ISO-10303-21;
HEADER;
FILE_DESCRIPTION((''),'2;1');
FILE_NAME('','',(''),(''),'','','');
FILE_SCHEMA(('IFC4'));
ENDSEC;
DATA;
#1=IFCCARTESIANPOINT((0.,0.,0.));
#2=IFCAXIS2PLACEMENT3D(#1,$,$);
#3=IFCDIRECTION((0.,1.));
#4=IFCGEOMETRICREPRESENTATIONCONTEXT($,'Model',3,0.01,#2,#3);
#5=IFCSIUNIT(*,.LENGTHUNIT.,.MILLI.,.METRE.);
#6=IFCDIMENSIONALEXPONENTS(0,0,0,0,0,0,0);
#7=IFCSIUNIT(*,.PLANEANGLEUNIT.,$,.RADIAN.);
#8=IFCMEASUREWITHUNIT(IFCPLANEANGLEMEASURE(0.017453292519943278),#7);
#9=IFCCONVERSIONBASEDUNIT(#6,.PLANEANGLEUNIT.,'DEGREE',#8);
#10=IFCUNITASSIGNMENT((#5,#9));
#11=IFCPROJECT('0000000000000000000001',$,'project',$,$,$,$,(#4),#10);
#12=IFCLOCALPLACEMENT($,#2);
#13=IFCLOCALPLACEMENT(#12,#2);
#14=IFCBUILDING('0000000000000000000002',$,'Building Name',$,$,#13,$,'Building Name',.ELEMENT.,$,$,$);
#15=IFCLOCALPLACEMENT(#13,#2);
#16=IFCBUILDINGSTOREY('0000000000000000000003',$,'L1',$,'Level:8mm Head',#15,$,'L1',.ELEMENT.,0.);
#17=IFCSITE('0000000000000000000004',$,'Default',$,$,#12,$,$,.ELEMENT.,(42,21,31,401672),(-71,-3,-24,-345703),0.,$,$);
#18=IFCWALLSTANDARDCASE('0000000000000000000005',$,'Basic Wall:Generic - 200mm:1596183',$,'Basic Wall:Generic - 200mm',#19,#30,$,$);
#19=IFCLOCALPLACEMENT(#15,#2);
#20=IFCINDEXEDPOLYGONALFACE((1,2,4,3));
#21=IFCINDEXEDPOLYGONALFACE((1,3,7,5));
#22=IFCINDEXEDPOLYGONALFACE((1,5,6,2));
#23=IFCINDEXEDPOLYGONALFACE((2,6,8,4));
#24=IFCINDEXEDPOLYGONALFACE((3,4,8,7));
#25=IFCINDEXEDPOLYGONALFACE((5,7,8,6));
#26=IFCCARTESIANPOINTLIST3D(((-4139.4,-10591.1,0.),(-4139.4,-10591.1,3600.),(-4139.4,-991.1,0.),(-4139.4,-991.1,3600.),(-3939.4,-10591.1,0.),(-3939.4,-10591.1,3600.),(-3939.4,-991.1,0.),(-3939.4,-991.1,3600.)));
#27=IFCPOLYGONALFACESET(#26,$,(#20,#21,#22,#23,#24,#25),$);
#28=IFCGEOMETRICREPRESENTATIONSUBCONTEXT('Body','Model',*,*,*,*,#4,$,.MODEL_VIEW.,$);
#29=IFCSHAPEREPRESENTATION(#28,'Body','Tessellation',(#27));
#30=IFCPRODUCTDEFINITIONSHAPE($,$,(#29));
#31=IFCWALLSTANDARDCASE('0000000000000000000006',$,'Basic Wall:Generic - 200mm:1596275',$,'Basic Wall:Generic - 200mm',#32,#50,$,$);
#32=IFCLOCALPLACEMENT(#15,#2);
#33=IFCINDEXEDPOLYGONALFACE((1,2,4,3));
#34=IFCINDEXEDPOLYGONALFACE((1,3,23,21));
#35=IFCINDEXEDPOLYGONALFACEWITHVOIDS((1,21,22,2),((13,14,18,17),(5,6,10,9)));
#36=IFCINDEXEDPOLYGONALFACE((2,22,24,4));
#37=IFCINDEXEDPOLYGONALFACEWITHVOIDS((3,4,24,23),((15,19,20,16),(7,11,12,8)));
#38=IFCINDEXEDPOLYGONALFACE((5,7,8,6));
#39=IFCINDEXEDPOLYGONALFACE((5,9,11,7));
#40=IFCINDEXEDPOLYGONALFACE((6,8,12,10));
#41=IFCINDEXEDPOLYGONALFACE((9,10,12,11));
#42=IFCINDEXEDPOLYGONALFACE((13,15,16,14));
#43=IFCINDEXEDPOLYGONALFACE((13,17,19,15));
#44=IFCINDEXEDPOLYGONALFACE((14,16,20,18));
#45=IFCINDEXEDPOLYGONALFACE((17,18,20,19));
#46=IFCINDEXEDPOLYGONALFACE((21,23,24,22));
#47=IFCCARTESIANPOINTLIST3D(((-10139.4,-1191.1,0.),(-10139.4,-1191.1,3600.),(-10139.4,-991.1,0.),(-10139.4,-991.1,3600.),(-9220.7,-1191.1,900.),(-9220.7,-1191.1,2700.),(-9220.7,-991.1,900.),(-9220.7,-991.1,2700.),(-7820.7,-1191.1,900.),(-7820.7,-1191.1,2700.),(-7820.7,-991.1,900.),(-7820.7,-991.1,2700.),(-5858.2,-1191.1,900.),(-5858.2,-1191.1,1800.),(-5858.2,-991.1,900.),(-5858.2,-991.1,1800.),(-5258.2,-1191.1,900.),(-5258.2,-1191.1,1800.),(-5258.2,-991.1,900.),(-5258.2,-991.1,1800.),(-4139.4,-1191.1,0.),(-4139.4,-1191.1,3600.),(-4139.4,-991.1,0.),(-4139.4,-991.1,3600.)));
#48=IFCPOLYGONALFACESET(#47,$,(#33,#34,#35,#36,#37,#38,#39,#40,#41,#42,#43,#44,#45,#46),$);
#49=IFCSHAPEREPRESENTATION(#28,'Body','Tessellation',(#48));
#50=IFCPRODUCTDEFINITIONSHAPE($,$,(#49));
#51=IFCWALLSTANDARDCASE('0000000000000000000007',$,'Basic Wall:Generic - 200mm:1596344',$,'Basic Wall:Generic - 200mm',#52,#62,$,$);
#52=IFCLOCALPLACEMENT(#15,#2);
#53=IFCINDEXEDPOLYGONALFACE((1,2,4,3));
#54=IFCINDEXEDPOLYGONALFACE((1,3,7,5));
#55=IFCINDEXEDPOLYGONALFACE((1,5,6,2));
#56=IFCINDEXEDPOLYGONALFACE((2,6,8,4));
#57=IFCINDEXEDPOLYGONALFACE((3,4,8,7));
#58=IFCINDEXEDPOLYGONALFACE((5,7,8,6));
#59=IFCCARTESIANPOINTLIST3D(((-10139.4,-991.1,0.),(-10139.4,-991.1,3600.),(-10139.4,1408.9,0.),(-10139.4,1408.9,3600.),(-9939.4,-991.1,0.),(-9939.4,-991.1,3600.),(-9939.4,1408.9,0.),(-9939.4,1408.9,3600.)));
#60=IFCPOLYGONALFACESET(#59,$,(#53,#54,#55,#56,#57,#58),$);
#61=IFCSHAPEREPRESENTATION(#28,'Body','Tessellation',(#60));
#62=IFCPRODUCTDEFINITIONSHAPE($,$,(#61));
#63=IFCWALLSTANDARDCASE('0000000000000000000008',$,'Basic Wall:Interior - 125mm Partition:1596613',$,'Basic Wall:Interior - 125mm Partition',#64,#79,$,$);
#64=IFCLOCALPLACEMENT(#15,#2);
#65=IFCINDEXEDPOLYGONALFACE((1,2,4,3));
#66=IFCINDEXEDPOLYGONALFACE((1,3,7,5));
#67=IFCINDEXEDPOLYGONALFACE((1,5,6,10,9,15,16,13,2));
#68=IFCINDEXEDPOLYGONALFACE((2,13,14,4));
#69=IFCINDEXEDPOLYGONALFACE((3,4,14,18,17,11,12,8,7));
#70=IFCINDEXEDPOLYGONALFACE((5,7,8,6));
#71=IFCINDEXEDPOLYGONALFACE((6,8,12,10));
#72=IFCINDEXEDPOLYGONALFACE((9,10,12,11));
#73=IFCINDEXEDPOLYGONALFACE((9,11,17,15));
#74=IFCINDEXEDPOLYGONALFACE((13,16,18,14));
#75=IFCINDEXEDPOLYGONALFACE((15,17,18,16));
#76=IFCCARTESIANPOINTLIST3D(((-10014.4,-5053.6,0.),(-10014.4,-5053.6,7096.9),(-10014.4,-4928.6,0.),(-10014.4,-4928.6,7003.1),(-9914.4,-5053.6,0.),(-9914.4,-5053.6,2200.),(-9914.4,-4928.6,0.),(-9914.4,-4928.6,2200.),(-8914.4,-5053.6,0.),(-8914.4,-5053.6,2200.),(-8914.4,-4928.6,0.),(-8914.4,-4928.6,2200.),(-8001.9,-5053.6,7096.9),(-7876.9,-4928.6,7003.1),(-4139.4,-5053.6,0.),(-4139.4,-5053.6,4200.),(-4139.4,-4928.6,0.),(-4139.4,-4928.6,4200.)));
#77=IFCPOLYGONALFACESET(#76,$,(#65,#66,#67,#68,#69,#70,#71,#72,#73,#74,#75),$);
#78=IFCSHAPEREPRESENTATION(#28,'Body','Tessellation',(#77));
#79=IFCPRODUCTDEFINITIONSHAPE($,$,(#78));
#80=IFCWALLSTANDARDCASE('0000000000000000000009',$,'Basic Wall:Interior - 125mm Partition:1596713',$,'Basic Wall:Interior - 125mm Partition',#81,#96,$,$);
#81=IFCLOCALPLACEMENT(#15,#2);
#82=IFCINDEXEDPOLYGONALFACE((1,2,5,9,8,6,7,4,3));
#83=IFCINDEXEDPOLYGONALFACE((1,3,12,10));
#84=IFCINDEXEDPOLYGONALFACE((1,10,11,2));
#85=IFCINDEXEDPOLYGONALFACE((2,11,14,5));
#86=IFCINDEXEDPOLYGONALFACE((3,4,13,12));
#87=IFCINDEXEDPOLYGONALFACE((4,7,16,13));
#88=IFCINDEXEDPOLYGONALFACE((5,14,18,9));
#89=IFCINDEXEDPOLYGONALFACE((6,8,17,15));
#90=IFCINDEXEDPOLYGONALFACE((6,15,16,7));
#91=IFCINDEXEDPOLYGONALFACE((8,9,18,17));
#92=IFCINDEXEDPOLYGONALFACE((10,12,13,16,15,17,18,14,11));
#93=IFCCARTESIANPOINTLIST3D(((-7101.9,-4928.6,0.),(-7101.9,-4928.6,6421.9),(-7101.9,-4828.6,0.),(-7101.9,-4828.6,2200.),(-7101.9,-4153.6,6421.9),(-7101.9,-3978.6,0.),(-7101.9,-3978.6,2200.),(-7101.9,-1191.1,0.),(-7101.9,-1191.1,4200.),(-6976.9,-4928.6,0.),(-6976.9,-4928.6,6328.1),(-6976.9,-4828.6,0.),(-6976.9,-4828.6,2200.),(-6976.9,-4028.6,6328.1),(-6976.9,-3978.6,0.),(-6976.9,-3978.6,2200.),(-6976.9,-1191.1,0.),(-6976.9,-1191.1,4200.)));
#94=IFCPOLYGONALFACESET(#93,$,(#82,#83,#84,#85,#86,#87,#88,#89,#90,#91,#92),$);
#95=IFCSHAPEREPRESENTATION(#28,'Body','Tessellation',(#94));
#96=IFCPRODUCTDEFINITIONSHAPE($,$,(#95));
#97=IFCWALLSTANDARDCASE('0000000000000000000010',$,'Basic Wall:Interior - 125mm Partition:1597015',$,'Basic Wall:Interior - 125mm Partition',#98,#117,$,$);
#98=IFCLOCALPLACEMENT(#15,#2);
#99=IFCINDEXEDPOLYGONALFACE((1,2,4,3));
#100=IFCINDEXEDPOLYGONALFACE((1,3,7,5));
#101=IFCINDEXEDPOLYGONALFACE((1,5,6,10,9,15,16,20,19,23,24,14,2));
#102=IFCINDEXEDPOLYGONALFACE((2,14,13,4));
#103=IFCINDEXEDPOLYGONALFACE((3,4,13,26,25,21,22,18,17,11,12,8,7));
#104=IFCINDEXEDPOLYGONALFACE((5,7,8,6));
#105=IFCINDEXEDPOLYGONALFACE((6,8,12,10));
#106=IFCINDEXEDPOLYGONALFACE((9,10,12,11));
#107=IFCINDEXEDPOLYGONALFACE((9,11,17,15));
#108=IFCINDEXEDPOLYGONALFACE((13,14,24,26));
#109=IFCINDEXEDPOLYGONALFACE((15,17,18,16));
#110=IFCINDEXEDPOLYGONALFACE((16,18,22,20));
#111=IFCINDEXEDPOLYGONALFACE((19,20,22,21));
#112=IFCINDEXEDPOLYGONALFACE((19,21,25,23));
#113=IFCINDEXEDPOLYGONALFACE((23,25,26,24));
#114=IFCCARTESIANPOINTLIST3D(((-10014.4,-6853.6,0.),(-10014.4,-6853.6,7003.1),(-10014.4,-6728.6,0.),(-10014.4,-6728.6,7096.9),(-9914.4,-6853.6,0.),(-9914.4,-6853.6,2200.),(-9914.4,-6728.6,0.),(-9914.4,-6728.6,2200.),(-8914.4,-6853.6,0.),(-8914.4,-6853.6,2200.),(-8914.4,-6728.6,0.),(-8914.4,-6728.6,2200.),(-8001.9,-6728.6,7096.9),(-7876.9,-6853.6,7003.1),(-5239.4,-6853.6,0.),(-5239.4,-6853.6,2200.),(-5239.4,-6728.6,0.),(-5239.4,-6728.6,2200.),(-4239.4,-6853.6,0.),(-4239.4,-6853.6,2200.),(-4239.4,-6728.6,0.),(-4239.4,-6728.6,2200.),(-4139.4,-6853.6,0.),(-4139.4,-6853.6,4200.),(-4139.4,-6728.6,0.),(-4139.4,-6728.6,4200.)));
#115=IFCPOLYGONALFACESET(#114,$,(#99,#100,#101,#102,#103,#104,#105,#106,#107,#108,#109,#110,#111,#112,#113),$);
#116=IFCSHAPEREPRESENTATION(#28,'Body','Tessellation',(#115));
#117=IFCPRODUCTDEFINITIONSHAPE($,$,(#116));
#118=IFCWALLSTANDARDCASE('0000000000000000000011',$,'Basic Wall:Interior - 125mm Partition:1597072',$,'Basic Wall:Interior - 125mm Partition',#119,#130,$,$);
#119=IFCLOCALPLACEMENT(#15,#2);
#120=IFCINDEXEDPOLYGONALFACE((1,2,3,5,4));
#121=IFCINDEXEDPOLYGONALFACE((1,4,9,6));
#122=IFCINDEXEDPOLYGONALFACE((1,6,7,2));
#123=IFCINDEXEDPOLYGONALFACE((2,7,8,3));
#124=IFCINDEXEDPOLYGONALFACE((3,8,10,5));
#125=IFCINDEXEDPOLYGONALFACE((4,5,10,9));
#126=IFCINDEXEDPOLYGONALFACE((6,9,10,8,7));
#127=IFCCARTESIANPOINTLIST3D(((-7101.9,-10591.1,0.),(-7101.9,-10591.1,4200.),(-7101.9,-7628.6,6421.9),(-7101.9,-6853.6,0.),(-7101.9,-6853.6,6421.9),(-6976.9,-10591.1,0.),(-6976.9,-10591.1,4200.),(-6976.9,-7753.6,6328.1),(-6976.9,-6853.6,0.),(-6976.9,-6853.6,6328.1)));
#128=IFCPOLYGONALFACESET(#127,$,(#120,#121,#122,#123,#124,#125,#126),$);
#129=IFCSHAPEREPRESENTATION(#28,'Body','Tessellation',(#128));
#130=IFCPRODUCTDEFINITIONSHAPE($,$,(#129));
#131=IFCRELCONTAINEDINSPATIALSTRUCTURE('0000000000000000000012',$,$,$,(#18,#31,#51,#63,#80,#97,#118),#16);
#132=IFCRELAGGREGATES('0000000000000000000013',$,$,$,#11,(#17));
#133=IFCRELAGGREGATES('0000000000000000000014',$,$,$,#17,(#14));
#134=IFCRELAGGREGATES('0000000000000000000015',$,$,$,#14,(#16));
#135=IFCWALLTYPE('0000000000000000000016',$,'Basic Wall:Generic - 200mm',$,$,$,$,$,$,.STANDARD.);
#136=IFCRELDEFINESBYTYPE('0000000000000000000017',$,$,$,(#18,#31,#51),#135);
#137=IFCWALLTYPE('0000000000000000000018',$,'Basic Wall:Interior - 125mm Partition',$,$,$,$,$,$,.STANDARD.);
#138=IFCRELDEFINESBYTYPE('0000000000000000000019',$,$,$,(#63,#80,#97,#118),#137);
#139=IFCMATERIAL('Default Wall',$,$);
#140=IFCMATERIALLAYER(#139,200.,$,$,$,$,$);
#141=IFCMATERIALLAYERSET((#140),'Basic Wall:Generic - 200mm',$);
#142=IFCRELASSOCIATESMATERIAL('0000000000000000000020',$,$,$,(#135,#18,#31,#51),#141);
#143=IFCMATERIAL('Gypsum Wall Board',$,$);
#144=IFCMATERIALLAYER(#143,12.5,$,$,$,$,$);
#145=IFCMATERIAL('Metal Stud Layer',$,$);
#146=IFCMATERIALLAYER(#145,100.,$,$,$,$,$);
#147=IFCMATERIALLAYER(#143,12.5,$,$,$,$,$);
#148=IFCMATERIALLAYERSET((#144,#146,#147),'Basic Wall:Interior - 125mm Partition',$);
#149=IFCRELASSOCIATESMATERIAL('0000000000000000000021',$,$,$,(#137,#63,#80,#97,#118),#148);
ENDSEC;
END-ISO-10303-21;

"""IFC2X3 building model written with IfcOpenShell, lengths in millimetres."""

from ifc_helpers import new_model, entity, si_unit, converted_unit, direction, frame, frame_2d, origin, place, context, subcontext, project, spatial, polyline, rectangle, extrude, clip, bounded_halfspace, material, layer, layer_set, layer_usage, type_object, element, save


model = new_model("IFC2X3")

# Units and contexts
model_context = context("Model", 3, precision=0.01, world=origin(), true_north=direction((0.0, 1.0)))
body_context = subcontext(model_context, "Body", "Model", "MODEL_VIEW")
ifc_project = project(units=[si_unit("LENGTHUNIT", "METRE", prefix="MILLI"), converted_unit("PLANEANGLEUNIT", "DEGREE", entity("IfcPlaneAngleMeasure", 0.017453292519943278), si_unit("PLANEANGLEUNIT", "RADIAN"), dimensions=[0, 0, 0, 0, 0, 0, 0])], contexts=[model_context])

# Site, building, storey
site_placement = place(None, origin())
site = spatial("IfcSite", under=ifc_project, at=site_placement, Name="Default", CompositionType="ELEMENT", RefLatitude=(42, 21, 31, 401672), RefLongitude=(-71, -3, -24, -345703), RefElevation=0.0)
building_placement = place(site_placement, origin())
building = spatial("IfcBuilding", under=site, at=building_placement, Name="Building Name", LongName="Building Name", CompositionType="ELEMENT")
storey_placement = place(building_placement, origin())
storey = spatial("IfcBuildingStorey", under=building, at=storey_placement, Name="L1", ObjectType="Level:8mm Head", LongName="L1", CompositionType="ELEMENT", Elevation=0.0)

# Wall
ifc_material_1 = material(Name="Default Wall")
ifc_layer_1 = layer(ifc_material_1, 200.0)
ifc_layer_set_1 = layer_set([ifc_layer_1], Name="Basic Wall:Generic - 200mm")
ifc_layer_usage_1 = layer_usage(ifc_layer_set_1, "AXIS2", "NEGATIVE", 100.0)
wall_type_1 = type_object("IfcWallType", Name="Basic Wall:Generic - 200mm", PredefinedType="STANDARD", material=ifc_layer_set_1)
wall_1_placement = place(storey_placement, frame((-4039.4, -10591.1, 0.0), z_axis=(0.0, 0.0, 1.0), x_axis=(0.0, 1.0, 0.0)))
element("IfcWallStandardCase", 1, at=wall_1_placement, inside=storey, type_object=wall_type_1, material=ifc_layer_usage_1, Name="Basic Wall:Generic - 200mm:1596183", ObjectType="Basic Wall:Generic - 200mm", context=body_context, shape_type="SweptSolid", body=[
    extrude(rectangle(XDim=9600.0, YDim=200.0, at=frame_2d((4800.0, 0.0), x_axis=(-1.0, 0.0))), origin(), (0.0, 0.0, 1.0), 3600.0),
])

# Wall, openings
wall_2_placement = place(storey_placement, frame((-4139.4, -1091.1, 0.0), z_axis=(0.0, 0.0, 1.0), x_axis=(-1.0, 0.0, 0.0)))
wall_2 = element("IfcWallStandardCase", 2, at=wall_2_placement, inside=storey, type_object=wall_type_1, material=ifc_layer_usage_1, Name="Basic Wall:Generic - 200mm:1596275", ObjectType="Basic Wall:Generic - 200mm", context=body_context, shape_type="SweptSolid", body=[
    extrude(rectangle(XDim=6000.0, YDim=200.0, at=frame_2d((3000.0, 0.0), x_axis=(-1.0, 0.0))), origin(), (0.0, 0.0, 1.0), 3600.0),
])
opening_1_placement = place(wall_2_placement, frame((5081.2, 100.0, 900.0)))
element("IfcOpeningElement", 3, at=opening_1_placement, cuts=wall_2, ObjectType="Opening", context=body_context, shape_type="SweptSolid", body=[
    extrude(rectangle(XDim=1800.0, YDim=1400.0, at=frame_2d((900.0, 700.0), x_axis=(-1.0, 0.0))), frame((0.0, 0.0, 0.0), z_axis=(0.0, -1.0, 0.0), x_axis=(0.0, 0.0, 1.0)), (0.0, 0.0, 1.0), 200.0),
])
opening_2_placement = place(wall_2_placement, frame((1118.8, -100.0, 900.0)))
element("IfcOpeningElement", 4, at=opening_2_placement, cuts=wall_2, ObjectType="Opening", context=body_context, shape_type="SweptSolid", body=[
    extrude(rectangle(XDim=900.0, YDim=600.0, at=frame_2d((450.0, 300.0), x_axis=(-1.0, 0.0))), frame((0.0, 0.0, 0.0), z_axis=(0.0, 1.0, 0.0), x_axis=(0.0, 0.0, 1.0)), (0.0, 0.0, 1.0), 200.0),
])

# Wall
wall_3_placement = place(storey_placement, frame((-10039.4, -991.1, 0.0), z_axis=(0.0, 0.0, 1.0), x_axis=(0.0, 1.0, 0.0)))
element("IfcWallStandardCase", 5, at=wall_3_placement, inside=storey, type_object=wall_type_1, material=ifc_layer_usage_1, Name="Basic Wall:Generic - 200mm:1596344", ObjectType="Basic Wall:Generic - 200mm", context=body_context, shape_type="SweptSolid", body=[
    extrude(rectangle(XDim=2400.0, YDim=200.0, at=frame_2d((1200.0, 0.0), x_axis=(-1.0, 0.0))), origin(), (0.0, 0.0, 1.0), 3600.0),
])

# Walls, openings
ifc_material_2 = material(Name="Gypsum Wall Board")
ifc_layer_2 = layer(ifc_material_2, 12.5)
ifc_material_3 = material(Name="Metal Stud Layer")
ifc_layer_3 = layer(ifc_material_3, 100.0)
ifc_layer_4 = layer(ifc_material_2, 12.5)
ifc_layer_set_2 = layer_set([ifc_layer_2, ifc_layer_3, ifc_layer_4], Name="Basic Wall:Interior - 125mm Partition")
ifc_layer_usage_2 = layer_usage(ifc_layer_set_2, "AXIS2", "NEGATIVE", 62.5)
wall_type_2 = type_object("IfcWallType", Name="Basic Wall:Interior - 125mm Partition", PredefinedType="STANDARD", material=ifc_layer_set_2)
wall_4_placement = place(storey_placement, frame((-10014.4, -4991.1, 0.0)))
wall_4 = element("IfcWallStandardCase", 6, at=wall_4_placement, inside=storey, type_object=wall_type_2, material=ifc_layer_usage_2, Name="Basic Wall:Interior - 125mm Partition:1596613", ObjectType="Basic Wall:Interior - 125mm Partition", context=body_context, shape_type="Clipping", body=[
    clip(clip(extrude(rectangle(XDim=125.0, YDim=5875.0, at=frame_2d((2937.5, 0.0), x_axis=(0.0, 1.0))), origin(), (0.0, 0.0, 1.0), 7096.9), bounded_halfspace(frame((5875.0, -62.5, 4200.0), z_axis=(0.6, 0.0, 0.8), x_axis=(0.0, 1.0, 0.0)), False, frame((5875.0, -62.5, 4200.0)), polyline([(0.0, 0.0), (0.0, 125.0), (-2837.5, 125.0), (-2962.5, 125.0), (-3737.5, 125.0), (-3862.5, 0.0), (0.0, 0.0)]))), bounded_halfspace(frame((0.0, 62.5, 7003.1), z_axis=(0.0, 0.6, 0.8), x_axis=(-1.0, 0.0, 0.0)), False, frame((0.0, 62.5, 7003.1)), polyline([(0.0, 0.0), (0.0, -125.0), (2012.5, -125.0), (2137.5, 0.0), (0.0, 0.0)]))),
])
opening_3_placement = place(wall_4_placement, frame((100.0, -62.5, 0.0)))
element("IfcOpeningElement", 7, at=opening_3_placement, cuts=wall_4, ObjectType="Opening", context=body_context, shape_type="SweptSolid", body=[
    extrude(rectangle(XDim=2200.0, YDim=1000.0, at=frame_2d((1100.0, 500.0), x_axis=(1.0, 0.0))), frame((0.0, 0.0, 0.0), z_axis=(0.0, 1.0, 0.0), x_axis=(0.0, 0.0, 1.0)), (0.0, 0.0, 1.0), 125.0),
])
wall_5_placement = place(storey_placement, frame((-7039.4, -4928.6, 0.0), z_axis=(0.0, 0.0, 1.0), x_axis=(0.0, 1.0, 0.0)))
wall_5 = element("IfcWallStandardCase", 8, at=wall_5_placement, inside=storey, type_object=wall_type_2, material=ifc_layer_usage_2, Name="Basic Wall:Interior - 125mm Partition:1596713", ObjectType="Basic Wall:Interior - 125mm Partition", context=body_context, shape_type="Clipping", body=[
    clip(clip(extrude(rectangle(XDim=125.0, YDim=3737.5, at=frame_2d((1868.8, 0.0), x_axis=(0.0, 1.0))), origin(), (0.0, 0.0, 1.0), 6421.9), bounded_halfspace(frame((0.0, 62.5, 6421.9), z_axis=(0.0, -0.6, 0.8), x_axis=(1.0, 0.0, 0.0)), False, frame((0.0, 62.5, 6421.9)), polyline([(0.0, 0.0), (0.0, -125.0), (900.0, -125.0), (775.0, 0.0), (0.0, 0.0)]))), bounded_halfspace(frame((3737.5, -62.5, 4200.0), z_axis=(0.6, 0.0, 0.8), x_axis=(0.0, 1.0, 0.0)), False, frame((3737.5, -62.5, 4200.0)), polyline([(0.0, 0.0), (0.0, 125.0), (-2962.5, 125.0), (-2837.5, 0.0), (0.0, 0.0)]))),
])
opening_4_placement = place(wall_5_placement, frame((100.0, -62.5, 0.0)))
element("IfcOpeningElement", 9, at=opening_4_placement, cuts=wall_5, ObjectType="Opening", context=body_context, shape_type="SweptSolid", body=[
    extrude(rectangle(XDim=2200.0, YDim=850.0, at=frame_2d((1100.0, 425.0), x_axis=(1.0, 0.0))), frame((0.0, 0.0, 0.0), z_axis=(0.0, 1.0, 0.0), x_axis=(0.0, 0.0, 1.0)), (0.0, 0.0, 1.0), 125.0),
])

# Wall, openings
wall_6_placement = place(storey_placement, frame((-10014.4, -6791.1, 0.0)))
wall_6 = element("IfcWallStandardCase", 10, at=wall_6_placement, inside=storey, type_object=wall_type_2, material=ifc_layer_usage_2, Name="Basic Wall:Interior - 125mm Partition:1597015", ObjectType="Basic Wall:Interior - 125mm Partition", context=body_context, shape_type="Clipping", body=[
    clip(clip(extrude(rectangle(XDim=5875.0, YDim=125.0, at=frame_2d((2937.5, 0.0), x_axis=(-1.0, 0.0))), origin(), (0.0, 0.0, 1.0), 7096.9), bounded_halfspace(frame((0.0, 62.5, 7096.9), z_axis=(0.0, -0.6, 0.8), x_axis=(1.0, 0.0, 0.0)), False, frame((0.0, 62.5, 7096.9)), polyline([(0.0, 0.0), (0.0, -125.0), (2137.5, -125.0), (2012.5, 0.0), (0.0, 0.0)]))), bounded_halfspace(frame((5875.0, -62.5, 4200.0), z_axis=(0.6, 0.0, 0.8), x_axis=(0.0, 1.0, 0.0)), False, frame((5875.0, -62.5, 4200.0)), polyline([(0.0, 0.0), (0.0, 125.0), (-3862.5, 125.0), (-3737.5, 0.0), (-2962.5, 0.0), (-2837.5, 0.0), (0.0, 0.0)]))),
])
opening_5_placement = place(wall_6_placement, frame((5775.0, 62.5, 0.0)))
element("IfcOpeningElement", 11, at=opening_5_placement, cuts=wall_6, ObjectType="Opening", context=body_context, shape_type="SweptSolid", body=[
    extrude(rectangle(XDim=2200.0, YDim=1000.0, at=frame_2d((1100.0, 500.0), x_axis=(1.0, 0.0))), frame((0.0, 0.0, 0.0), z_axis=(0.0, -1.0, 0.0), x_axis=(0.0, 0.0, 1.0)), (0.0, 0.0, 1.0), 125.0),
])
opening_6_placement = place(wall_6_placement, frame((1100.0, 62.5, 0.0)))
element("IfcOpeningElement", 12, at=opening_6_placement, cuts=wall_6, ObjectType="Opening", context=body_context, shape_type="SweptSolid", body=[
    extrude(rectangle(XDim=2200.0, YDim=1000.0, at=frame_2d((1100.0, 500.0), x_axis=(1.0, 0.0))), frame((0.0, 0.0, 0.0), z_axis=(0.0, -1.0, 0.0), x_axis=(0.0, 0.0, 1.0)), (0.0, 0.0, 1.0), 125.0),
])

# Wall
wall_7_placement = place(storey_placement, frame((-7039.4, -6853.6, 0.0), z_axis=(0.0, 0.0, 1.0), x_axis=(0.0, -1.0, 0.0)))
element("IfcWallStandardCase", 13, at=wall_7_placement, inside=storey, type_object=wall_type_2, material=ifc_layer_usage_2, Name="Basic Wall:Interior - 125mm Partition:1597072", ObjectType="Basic Wall:Interior - 125mm Partition", context=body_context, shape_type="Clipping", body=[
    clip(clip(extrude(rectangle(XDim=3737.5, YDim=125.0, at=frame_2d((1868.8, 0.0), x_axis=(-1.0, 0.0))), origin(), (0.0, 0.0, 1.0), 6421.9), bounded_halfspace(frame((775.0, -62.5, 6421.9), z_axis=(0.6, 0.0, 0.8), x_axis=(0.0, 1.0, 0.0)), False, frame((775.0, -62.5, 6421.9)), polyline([(0.0, 0.0), (2962.5, 0.0), (2962.5, 125.0), (125.0, 125.0), (0.0, 0.0)]))), bounded_halfspace(frame((0.0, -62.5, 6421.9), z_axis=(0.0, 0.6, 0.8), x_axis=(-1.0, 0.0, 0.0)), False, frame((0.0, -62.5, 6421.9)), polyline([(0.0, 0.0), (775.0, 0.0), (900.0, 125.0), (0.0, 125.0), (0.0, 0.0)]))),
])

save(model, "model.ifc")
